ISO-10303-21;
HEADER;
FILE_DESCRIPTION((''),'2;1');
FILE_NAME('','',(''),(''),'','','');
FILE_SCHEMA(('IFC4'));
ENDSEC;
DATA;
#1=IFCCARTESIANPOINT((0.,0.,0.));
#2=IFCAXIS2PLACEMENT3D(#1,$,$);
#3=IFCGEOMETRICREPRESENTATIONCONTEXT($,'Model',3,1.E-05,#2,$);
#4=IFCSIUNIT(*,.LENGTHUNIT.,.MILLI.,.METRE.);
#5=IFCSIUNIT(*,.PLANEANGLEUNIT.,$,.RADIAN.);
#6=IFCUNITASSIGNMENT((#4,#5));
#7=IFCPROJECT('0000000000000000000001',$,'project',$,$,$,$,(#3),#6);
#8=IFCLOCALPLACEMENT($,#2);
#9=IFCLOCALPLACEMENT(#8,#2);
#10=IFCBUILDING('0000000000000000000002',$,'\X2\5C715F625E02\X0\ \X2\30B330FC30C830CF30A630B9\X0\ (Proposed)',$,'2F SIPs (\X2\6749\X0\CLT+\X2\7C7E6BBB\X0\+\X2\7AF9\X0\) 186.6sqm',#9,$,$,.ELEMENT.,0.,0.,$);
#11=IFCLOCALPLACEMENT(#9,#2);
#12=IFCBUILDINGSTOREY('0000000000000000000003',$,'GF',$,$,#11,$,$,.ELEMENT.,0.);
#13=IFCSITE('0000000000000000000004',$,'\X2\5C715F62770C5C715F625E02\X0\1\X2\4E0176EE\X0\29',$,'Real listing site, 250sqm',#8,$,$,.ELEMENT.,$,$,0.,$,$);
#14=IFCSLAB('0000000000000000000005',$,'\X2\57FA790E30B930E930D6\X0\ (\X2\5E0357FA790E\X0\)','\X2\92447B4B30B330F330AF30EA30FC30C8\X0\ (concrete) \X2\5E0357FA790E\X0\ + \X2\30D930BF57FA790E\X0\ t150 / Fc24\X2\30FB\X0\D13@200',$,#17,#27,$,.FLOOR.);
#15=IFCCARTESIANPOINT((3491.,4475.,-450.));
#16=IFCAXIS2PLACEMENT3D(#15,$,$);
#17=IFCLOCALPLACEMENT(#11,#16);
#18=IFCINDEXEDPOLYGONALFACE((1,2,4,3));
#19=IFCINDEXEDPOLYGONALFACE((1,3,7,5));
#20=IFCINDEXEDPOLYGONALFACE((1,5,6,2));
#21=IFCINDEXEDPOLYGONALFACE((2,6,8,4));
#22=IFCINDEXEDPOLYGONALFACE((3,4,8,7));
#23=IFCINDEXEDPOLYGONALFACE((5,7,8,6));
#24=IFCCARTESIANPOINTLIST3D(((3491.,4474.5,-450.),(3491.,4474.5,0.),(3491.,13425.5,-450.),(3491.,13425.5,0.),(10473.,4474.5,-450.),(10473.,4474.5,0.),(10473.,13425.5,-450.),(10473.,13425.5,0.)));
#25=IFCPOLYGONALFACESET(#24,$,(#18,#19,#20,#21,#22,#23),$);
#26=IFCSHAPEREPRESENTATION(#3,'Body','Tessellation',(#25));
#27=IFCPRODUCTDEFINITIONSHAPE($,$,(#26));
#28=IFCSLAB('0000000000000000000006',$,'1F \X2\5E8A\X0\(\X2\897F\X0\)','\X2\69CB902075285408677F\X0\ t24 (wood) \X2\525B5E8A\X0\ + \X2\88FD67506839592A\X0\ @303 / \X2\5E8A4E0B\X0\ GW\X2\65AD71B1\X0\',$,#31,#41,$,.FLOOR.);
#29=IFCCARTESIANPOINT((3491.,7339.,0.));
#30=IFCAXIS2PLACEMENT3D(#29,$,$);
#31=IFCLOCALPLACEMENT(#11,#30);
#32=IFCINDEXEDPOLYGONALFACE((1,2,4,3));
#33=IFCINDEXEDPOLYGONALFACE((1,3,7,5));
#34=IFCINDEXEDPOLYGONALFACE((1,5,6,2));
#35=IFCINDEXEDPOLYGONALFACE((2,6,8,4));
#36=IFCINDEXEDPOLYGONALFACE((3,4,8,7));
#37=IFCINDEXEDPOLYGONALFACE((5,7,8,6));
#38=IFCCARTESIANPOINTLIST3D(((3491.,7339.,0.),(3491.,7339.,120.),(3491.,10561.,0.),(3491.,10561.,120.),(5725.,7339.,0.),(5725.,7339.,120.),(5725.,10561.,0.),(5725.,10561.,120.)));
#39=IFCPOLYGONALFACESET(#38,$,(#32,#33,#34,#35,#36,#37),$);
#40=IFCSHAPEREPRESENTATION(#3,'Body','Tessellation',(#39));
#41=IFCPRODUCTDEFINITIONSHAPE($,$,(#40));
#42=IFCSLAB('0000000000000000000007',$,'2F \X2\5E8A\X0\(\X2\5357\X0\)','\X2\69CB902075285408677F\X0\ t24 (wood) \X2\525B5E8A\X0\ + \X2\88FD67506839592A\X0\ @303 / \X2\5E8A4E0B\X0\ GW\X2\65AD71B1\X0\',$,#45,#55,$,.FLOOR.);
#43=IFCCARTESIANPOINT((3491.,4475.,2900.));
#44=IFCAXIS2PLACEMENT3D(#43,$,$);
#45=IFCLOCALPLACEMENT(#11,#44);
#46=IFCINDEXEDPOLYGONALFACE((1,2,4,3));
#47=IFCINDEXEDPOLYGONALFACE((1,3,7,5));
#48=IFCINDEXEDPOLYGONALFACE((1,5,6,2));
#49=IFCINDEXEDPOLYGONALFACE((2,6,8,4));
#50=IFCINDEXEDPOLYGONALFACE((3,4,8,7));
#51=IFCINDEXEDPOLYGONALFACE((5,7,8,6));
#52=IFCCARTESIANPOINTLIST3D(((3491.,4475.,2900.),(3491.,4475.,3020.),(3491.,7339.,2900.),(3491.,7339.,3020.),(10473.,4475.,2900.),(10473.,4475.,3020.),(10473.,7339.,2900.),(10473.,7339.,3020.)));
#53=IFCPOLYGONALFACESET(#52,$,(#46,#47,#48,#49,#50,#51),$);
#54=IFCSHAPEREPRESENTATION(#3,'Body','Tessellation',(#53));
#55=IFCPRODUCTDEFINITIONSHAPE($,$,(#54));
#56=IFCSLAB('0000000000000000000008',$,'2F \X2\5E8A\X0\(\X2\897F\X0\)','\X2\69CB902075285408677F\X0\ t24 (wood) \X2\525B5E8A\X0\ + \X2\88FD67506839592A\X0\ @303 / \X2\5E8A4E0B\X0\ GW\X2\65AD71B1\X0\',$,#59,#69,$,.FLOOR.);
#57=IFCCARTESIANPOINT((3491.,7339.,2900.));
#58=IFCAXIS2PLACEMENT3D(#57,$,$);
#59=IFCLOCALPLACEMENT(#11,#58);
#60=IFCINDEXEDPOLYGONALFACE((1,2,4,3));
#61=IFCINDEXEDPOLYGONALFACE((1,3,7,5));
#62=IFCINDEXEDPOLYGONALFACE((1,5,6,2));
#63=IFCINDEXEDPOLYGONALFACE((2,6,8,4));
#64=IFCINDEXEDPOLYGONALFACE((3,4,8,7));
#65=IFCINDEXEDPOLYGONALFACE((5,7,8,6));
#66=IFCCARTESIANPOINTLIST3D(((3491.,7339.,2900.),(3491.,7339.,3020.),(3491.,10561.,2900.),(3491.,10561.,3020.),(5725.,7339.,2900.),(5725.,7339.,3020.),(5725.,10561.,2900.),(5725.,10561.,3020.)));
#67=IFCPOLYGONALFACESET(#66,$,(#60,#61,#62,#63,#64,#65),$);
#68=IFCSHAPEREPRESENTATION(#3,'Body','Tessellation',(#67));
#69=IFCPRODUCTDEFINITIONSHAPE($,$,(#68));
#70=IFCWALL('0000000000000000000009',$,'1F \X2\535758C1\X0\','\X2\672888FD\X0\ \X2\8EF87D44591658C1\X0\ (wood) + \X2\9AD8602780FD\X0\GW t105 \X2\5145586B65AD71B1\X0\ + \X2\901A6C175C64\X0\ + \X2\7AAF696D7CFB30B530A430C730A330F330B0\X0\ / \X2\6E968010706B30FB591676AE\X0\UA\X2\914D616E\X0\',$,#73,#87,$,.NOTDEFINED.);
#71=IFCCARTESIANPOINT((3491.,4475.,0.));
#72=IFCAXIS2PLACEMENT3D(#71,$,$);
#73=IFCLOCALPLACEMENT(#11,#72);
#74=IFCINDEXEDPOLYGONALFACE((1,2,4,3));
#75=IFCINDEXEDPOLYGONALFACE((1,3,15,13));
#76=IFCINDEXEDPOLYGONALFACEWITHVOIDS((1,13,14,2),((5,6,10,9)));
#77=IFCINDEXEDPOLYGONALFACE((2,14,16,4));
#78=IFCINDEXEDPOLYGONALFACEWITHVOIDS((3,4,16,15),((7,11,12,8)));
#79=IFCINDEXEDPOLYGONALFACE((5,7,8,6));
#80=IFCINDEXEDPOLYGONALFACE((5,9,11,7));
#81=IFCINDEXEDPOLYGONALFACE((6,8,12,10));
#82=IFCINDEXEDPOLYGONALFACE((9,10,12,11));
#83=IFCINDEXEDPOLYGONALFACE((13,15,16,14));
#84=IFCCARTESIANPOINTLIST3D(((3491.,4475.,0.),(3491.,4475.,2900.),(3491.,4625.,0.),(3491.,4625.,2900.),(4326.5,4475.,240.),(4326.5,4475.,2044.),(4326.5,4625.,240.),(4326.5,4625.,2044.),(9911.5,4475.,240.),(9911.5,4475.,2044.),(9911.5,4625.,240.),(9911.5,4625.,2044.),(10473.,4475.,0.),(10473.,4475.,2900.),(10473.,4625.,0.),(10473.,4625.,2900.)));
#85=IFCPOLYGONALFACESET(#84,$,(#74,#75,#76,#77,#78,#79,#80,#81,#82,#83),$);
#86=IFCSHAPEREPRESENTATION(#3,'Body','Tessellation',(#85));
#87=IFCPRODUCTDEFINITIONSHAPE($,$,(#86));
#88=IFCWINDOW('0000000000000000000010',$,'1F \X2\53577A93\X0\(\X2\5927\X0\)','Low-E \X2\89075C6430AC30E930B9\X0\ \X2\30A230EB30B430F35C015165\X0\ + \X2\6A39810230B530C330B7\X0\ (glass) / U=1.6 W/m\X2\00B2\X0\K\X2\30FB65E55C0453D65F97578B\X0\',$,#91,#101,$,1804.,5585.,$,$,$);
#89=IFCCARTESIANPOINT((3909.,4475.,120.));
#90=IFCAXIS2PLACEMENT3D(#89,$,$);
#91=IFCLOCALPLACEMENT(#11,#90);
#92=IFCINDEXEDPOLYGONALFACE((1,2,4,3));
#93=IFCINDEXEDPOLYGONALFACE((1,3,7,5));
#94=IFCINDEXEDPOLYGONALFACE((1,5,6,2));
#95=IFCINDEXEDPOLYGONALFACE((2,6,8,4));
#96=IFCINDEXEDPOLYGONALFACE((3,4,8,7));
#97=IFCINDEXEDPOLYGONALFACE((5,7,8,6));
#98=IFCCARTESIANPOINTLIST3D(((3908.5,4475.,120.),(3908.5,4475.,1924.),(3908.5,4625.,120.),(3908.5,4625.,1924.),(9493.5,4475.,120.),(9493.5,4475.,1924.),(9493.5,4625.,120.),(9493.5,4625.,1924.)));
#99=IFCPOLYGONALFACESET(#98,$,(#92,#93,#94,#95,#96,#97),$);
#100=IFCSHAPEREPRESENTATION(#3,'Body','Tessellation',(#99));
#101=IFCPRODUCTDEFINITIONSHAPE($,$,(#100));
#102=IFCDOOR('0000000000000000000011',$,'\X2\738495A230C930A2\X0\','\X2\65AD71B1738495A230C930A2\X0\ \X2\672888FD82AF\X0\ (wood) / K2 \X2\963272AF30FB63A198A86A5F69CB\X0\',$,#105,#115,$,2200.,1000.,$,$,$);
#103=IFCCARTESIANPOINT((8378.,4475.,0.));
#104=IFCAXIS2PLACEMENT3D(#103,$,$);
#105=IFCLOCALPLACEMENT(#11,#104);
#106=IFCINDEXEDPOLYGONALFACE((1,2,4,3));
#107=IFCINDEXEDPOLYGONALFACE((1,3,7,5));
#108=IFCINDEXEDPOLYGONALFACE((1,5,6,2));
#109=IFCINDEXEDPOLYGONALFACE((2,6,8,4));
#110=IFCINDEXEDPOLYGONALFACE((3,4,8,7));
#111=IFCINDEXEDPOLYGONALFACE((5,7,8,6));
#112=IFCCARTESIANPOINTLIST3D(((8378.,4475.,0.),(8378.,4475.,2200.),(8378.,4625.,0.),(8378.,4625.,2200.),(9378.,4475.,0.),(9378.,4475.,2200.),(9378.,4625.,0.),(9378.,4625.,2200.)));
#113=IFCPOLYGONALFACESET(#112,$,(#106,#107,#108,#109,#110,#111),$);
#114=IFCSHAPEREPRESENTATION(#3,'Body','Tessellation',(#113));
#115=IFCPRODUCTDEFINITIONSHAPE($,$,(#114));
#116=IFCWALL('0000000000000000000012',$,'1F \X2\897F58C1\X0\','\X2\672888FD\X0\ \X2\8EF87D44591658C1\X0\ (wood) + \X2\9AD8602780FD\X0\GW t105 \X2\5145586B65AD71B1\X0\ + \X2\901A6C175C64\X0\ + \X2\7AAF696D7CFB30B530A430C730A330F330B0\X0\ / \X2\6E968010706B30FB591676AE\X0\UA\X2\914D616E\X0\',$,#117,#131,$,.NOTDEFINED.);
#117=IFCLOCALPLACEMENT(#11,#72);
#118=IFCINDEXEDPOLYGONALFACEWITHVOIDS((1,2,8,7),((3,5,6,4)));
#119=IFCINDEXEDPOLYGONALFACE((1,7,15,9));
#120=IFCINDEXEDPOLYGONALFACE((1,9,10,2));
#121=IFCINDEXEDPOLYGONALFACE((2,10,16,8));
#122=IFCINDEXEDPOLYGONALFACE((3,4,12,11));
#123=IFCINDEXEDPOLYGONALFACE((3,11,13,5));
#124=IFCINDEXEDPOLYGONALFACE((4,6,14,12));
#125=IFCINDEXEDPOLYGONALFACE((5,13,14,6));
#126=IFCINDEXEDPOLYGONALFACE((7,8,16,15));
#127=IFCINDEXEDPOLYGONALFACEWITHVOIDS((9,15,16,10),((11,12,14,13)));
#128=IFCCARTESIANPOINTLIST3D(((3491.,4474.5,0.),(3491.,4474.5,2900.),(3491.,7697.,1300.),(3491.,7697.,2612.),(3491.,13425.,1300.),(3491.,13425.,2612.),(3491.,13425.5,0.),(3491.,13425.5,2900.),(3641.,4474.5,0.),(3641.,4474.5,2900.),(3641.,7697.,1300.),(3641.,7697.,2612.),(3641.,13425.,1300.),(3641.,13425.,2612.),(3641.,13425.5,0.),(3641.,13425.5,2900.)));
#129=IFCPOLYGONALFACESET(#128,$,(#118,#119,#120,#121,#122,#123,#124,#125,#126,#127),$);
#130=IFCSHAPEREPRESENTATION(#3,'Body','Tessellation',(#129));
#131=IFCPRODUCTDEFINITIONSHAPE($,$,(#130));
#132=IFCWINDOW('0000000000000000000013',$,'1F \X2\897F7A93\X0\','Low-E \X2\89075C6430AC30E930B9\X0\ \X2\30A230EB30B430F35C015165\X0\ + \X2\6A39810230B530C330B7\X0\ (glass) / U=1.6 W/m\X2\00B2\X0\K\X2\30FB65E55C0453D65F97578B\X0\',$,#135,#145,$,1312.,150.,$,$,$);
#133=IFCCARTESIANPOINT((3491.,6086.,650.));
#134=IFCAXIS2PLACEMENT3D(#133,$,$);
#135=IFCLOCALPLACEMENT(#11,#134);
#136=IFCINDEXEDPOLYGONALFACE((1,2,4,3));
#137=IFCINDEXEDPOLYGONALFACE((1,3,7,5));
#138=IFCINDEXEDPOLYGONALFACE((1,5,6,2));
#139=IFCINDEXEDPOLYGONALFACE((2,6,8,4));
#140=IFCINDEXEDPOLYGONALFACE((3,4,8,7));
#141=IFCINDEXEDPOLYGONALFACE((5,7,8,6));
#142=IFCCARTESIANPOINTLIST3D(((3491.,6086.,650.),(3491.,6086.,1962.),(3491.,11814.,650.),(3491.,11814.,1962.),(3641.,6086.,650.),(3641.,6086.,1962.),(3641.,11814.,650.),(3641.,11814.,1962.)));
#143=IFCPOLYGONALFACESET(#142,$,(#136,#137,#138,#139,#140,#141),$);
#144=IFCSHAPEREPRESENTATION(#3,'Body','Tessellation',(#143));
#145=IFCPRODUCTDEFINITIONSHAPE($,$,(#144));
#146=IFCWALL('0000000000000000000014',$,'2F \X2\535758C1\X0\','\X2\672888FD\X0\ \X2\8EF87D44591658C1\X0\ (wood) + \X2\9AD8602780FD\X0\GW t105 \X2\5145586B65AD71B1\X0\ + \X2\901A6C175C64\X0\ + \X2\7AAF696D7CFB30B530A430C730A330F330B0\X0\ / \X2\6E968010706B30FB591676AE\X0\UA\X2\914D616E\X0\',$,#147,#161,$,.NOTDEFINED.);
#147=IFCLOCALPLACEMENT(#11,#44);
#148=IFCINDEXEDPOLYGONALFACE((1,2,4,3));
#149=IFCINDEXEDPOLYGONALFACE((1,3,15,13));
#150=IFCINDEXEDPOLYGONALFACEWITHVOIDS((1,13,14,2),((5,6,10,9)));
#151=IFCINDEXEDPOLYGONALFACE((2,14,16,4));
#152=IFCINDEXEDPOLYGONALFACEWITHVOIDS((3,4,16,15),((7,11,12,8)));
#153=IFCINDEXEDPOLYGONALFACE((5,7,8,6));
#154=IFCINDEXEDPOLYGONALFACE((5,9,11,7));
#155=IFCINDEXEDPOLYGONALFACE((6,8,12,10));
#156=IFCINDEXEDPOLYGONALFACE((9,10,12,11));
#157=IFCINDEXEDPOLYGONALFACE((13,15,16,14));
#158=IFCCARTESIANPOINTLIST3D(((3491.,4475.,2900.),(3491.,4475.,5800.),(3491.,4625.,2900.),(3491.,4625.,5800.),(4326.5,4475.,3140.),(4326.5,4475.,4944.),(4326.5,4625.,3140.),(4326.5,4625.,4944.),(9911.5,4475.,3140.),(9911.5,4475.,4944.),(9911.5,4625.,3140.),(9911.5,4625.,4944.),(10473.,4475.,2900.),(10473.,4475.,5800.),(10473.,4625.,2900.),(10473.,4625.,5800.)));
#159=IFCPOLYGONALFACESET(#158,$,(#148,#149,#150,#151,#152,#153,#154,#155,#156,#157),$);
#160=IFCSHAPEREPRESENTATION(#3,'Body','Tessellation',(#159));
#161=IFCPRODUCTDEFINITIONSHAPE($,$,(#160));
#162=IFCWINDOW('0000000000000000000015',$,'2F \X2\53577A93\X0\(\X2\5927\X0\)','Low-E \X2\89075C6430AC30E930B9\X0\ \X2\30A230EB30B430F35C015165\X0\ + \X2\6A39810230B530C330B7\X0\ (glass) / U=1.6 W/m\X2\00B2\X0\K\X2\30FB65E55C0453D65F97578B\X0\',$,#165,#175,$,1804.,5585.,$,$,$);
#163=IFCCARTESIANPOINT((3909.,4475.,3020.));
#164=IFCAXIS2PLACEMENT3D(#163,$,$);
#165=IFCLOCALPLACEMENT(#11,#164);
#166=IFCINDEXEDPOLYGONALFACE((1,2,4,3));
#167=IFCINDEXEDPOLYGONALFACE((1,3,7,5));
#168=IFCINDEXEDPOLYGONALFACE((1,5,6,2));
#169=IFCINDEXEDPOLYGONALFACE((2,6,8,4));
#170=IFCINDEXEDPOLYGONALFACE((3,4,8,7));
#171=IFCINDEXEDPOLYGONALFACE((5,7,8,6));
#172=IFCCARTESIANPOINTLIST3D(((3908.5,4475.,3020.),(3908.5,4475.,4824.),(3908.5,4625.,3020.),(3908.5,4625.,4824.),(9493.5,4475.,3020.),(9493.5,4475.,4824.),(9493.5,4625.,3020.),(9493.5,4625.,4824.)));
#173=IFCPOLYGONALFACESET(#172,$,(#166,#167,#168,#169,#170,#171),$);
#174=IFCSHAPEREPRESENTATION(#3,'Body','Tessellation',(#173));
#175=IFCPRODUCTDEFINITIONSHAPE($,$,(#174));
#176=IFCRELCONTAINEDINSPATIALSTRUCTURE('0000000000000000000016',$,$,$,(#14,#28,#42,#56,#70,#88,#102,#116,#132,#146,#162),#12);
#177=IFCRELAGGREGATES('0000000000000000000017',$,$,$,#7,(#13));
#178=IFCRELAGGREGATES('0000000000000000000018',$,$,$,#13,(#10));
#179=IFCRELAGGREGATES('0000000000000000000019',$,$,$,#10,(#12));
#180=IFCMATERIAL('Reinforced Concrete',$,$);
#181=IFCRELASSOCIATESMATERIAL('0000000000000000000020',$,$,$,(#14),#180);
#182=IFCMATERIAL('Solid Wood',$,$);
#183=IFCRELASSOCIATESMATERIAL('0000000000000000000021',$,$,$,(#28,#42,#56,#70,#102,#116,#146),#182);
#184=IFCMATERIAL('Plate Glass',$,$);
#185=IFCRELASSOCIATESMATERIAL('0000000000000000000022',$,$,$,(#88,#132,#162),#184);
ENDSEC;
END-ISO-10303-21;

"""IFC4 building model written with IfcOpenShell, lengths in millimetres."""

from ifc_helpers import new_model, si_unit, frame, frame_2d, origin, place, context, project, spatial, rectangle, extrude, material, element, fill, save


model = new_model("IFC4")

# Units and contexts
model_context = context("Model", 3, precision=1e-05, world=origin())
ifc_project = project(units=[si_unit("LENGTHUNIT", "METRE", prefix="MILLI"), si_unit("PLANEANGLEUNIT", "RADIAN")], contexts=[model_context])

# Site, building, storey
site_placement = place(None, origin())
site = spatial("IfcSite", under=ifc_project, at=site_placement, Name="山形県山形市1丁目29", ObjectType="Real listing site, 250sqm", CompositionType="ELEMENT", RefElevation=0.0)
building_placement = place(site_placement, origin())
building = spatial("IfcBuilding", under=site, at=building_placement, Name="山形市 コートハウス (Proposed)", ObjectType="2F SIPs (杉CLT+籾殻+竹) 186.6sqm", CompositionType="ELEMENT", ElevationOfRefHeight=0.0, ElevationOfTerrain=0.0)
storey_placement = place(building_placement, origin())
storey = spatial("IfcBuildingStorey", under=building, at=storey_placement, Name="GF", CompositionType="ELEMENT", Elevation=0.0)

# Slabs
ifc_material_1 = material(Name="Reinforced Concrete")
slab_1_placement = place(storey_placement, frame((3491.0, 4475.0, -450.0)))
element("IfcSlab", 1, at=slab_1_placement, inside=storey, material=ifc_material_1, Name="基礎スラブ (布基礎)", Description="鉄筋コンクリート (concrete) 布基礎 + ベタ基礎 t150 / Fc24・D13@200", PredefinedType="FLOOR", context=model_context, shape_type="SweptSolid", body=[
    extrude(rectangle(XDim=6982.0, YDim=8951.0, at=frame_2d((3491.0, 4475.0))), frame((3491.0, 4475.0, -450.0)), (0.0, 0.0, 1.0), 450.0),
])
ifc_material_2 = material(Name="Solid Wood")
slab_2_placement = place(storey_placement, frame((3491.0, 7339.0, 0.0)))
element("IfcSlab", 2, at=slab_2_placement, inside=storey, material=ifc_material_2, Name="1F 床(西)", Description="構造用合板 t24 (wood) 剛床 + 製材根太 @303 / 床下 GW断熱", PredefinedType="FLOOR", context=model_context, shape_type="SweptSolid", body=[
    extrude(rectangle(XDim=2234.0, YDim=3222.0, at=frame_2d((1117.0, 1611.0))), frame((3491.0, 7339.0, 0.0)), (0.0, 0.0, 1.0), 120.0),
])
slab_3_placement = place(storey_placement, frame((3491.0, 4475.0, 2900.0)))
element("IfcSlab", 3, at=slab_3_placement, inside=storey, material=ifc_material_2, Name="2F 床(南)", Description="構造用合板 t24 (wood) 剛床 + 製材根太 @303 / 床下 GW断熱", PredefinedType="FLOOR", context=model_context, shape_type="SweptSolid", body=[
    extrude(rectangle(XDim=6982.0, YDim=2864.0, at=frame_2d((3491.0, 1432.0))), frame((3491.0, 4475.0, 2900.0)), (0.0, 0.0, 1.0), 120.0),
])
slab_4_placement = place(storey_placement, frame((3491.0, 7339.0, 2900.0)))
element("IfcSlab", 4, at=slab_4_placement, inside=storey, material=ifc_material_2, Name="2F 床(西)", Description="構造用合板 t24 (wood) 剛床 + 製材根太 @303 / 床下 GW断熱", PredefinedType="FLOOR", context=model_context, shape_type="SweptSolid", body=[
    extrude(rectangle(XDim=2234.0, YDim=3222.0, at=frame_2d((1117.0, 1611.0))), frame((3491.0, 7339.0, 2900.0)), (0.0, 0.0, 1.0), 120.0),
])

# Wall, openings, window, door
wall_1_placement = place(storey_placement, frame((3491.0, 4475.0, 0.0)))
wall_1 = element("IfcWall", 5, at=wall_1_placement, inside=storey, material=ifc_material_2, Name="1F 南壁", Description="木製 軸組外壁 (wood) + 高性能GW t105 充填断熱 + 通気層 + 窯業系サイディング / 準耐火・外皮UA配慮", PredefinedType="NOTDEFINED", context=model_context, shape_type="SweptSolid", body=[
    extrude(rectangle(XDim=6982.0, YDim=150.0, at=frame_2d((3491.0, 75.0))), frame((3491.0, 4475.0, 0.0)), (0.0, 0.0, 1.0), 2900.0),
])
opening_1_placement = place(storey_placement, frame((3909.0, 4475.0, 120.0)))
opening_1 = element("IfcOpeningElement", 6, at=opening_1_placement, cuts=wall_1, PredefinedType="NOTDEFINED", context=model_context, shape_type="SweptSolid", body=[
    extrude(rectangle(XDim=5585.0, YDim=150.0, at=frame_2d((2792.0, 75.0))), frame((3909.0, 4475.0, 120.0)), (0.0, 0.0, 1.0), 1804.0),
])
opening_2_placement = place(storey_placement, frame((8378.0, 4475.0, 0.0)))
opening_2 = element("IfcOpeningElement", 7, at=opening_2_placement, cuts=wall_1, PredefinedType="NOTDEFINED", context=model_context, shape_type="SweptSolid", body=[
    extrude(rectangle(XDim=1000.0, YDim=150.0, at=frame_2d((500.0, 75.0))), frame((8378.0, 4475.0, 0.0)), (0.0, 0.0, 1.0), 2200.0),
])
ifc_material_3 = material(Name="Plate Glass")
window_1_placement = place(storey_placement, frame((3909.0, 4475.0, 120.0)))
window_1 = element("IfcWindow", 8, at=window_1_placement, inside=storey, material=ifc_material_3, Name="1F 南窓(大)", Description="Low-E 複層ガラス アルゴン封入 + 樹脂サッシ (glass) / U=1.6 W/m²K・日射取得型", OverallHeight=1804.0, OverallWidth=5585.0, context=model_context, shape_type="SweptSolid", body=[
    extrude(rectangle(XDim=5585.0, YDim=150.0, at=frame_2d((2792.0, 75.0))), frame((3909.0, 4475.0, 120.0)), (0.0, 0.0, 1.0), 1804.0),
])
fill(opening_1, window_1)
door_placement = place(storey_placement, frame((8378.0, 4475.0, 0.0)))
door = element("IfcDoor", 9, at=door_placement, inside=storey, material=ifc_material_2, Name="玄関ドア", Description="断熱玄関ドア 木製芯 (wood) / K2 防犯・採風機構", OverallHeight=2200.0, OverallWidth=1000.0, context=model_context, shape_type="SweptSolid", body=[
    extrude(rectangle(XDim=1000.0, YDim=150.0, at=frame_2d((500.0, 75.0))), frame((8378.0, 4475.0, 0.0)), (0.0, 0.0, 1.0), 2200.0),
])
fill(opening_2, door)

# Walls, openings, windows
wall_2_placement = place(storey_placement, frame((3491.0, 4475.0, 0.0)))
wall_2 = element("IfcWall", 10, at=wall_2_placement, inside=storey, material=ifc_material_2, Name="1F 西壁", Description="木製 軸組外壁 (wood) + 高性能GW t105 充填断熱 + 通気層 + 窯業系サイディング / 準耐火・外皮UA配慮", PredefinedType="NOTDEFINED", context=model_context, shape_type="SweptSolid", body=[
    extrude(rectangle(XDim=150.0, YDim=8951.0, at=frame_2d((75.0, 4475.0))), frame((3491.0, 4475.0, 0.0)), (0.0, 0.0, 1.0), 2900.0),
])
opening_3_placement = place(storey_placement, frame((3491.0, 6086.0, 650.0)))
opening_3 = element("IfcOpeningElement", 11, at=opening_3_placement, cuts=wall_2, PredefinedType="NOTDEFINED", context=model_context, shape_type="SweptSolid", body=[
    extrude(rectangle(XDim=150.0, YDim=5728.0, at=frame_2d((75.0, 2864.0))), frame((3491.0, 6086.0, 650.0)), (0.0, 0.0, 1.0), 1312.0),
])
window_2_placement = place(storey_placement, frame((3491.0, 6086.0, 650.0)))
window_2 = element("IfcWindow", 12, at=window_2_placement, inside=storey, material=ifc_material_3, Name="1F 西窓", Description="Low-E 複層ガラス アルゴン封入 + 樹脂サッシ (glass) / U=1.6 W/m²K・日射取得型", OverallHeight=1312.0, OverallWidth=150.0, context=model_context, shape_type="SweptSolid", body=[
    extrude(rectangle(XDim=150.0, YDim=5728.0, at=frame_2d((75.0, 2864.0))), frame((3491.0, 6086.0, 650.0)), (0.0, 0.0, 1.0), 1312.0),
])
fill(opening_3, window_2)
wall_3_placement = place(storey_placement, frame((3491.0, 4475.0, 2900.0)))
wall_3 = element("IfcWall", 13, at=wall_3_placement, inside=storey, material=ifc_material_2, Name="2F 南壁", Description="木製 軸組外壁 (wood) + 高性能GW t105 充填断熱 + 通気層 + 窯業系サイディング / 準耐火・外皮UA配慮", PredefinedType="NOTDEFINED", context=model_context, shape_type="SweptSolid", body=[
    extrude(rectangle(XDim=6982.0, YDim=150.0, at=frame_2d((3491.0, 75.0))), frame((3491.0, 4475.0, 2900.0)), (0.0, 0.0, 1.0), 2900.0),
])
opening_4_placement = place(storey_placement, frame((3909.0, 4475.0, 3020.0)))
opening_4 = element("IfcOpeningElement", 14, at=opening_4_placement, cuts=wall_3, PredefinedType="NOTDEFINED", context=model_context, shape_type="SweptSolid", body=[
    extrude(rectangle(XDim=5585.0, YDim=150.0, at=frame_2d((2792.0, 75.0))), frame((3909.0, 4475.0, 3020.0)), (0.0, 0.0, 1.0), 1804.0),
])
window_3_placement = place(storey_placement, frame((3909.0, 4475.0, 3020.0)))
window_3 = element("IfcWindow", 15, at=window_3_placement, inside=storey, material=ifc_material_3, Name="2F 南窓(大)", Description="Low-E 複層ガラス アルゴン封入 + 樹脂サッシ (glass) / U=1.6 W/m²K・日射取得型", OverallHeight=1804.0, OverallWidth=5585.0, context=model_context, shape_type="SweptSolid", body=[
    extrude(rectangle(XDim=5585.0, YDim=150.0, at=frame_2d((2792.0, 75.0))), frame((3909.0, 4475.0, 3020.0)), (0.0, 0.0, 1.0), 1804.0),
])
fill(opening_4, window_3)

save(model, "model.ifc")
